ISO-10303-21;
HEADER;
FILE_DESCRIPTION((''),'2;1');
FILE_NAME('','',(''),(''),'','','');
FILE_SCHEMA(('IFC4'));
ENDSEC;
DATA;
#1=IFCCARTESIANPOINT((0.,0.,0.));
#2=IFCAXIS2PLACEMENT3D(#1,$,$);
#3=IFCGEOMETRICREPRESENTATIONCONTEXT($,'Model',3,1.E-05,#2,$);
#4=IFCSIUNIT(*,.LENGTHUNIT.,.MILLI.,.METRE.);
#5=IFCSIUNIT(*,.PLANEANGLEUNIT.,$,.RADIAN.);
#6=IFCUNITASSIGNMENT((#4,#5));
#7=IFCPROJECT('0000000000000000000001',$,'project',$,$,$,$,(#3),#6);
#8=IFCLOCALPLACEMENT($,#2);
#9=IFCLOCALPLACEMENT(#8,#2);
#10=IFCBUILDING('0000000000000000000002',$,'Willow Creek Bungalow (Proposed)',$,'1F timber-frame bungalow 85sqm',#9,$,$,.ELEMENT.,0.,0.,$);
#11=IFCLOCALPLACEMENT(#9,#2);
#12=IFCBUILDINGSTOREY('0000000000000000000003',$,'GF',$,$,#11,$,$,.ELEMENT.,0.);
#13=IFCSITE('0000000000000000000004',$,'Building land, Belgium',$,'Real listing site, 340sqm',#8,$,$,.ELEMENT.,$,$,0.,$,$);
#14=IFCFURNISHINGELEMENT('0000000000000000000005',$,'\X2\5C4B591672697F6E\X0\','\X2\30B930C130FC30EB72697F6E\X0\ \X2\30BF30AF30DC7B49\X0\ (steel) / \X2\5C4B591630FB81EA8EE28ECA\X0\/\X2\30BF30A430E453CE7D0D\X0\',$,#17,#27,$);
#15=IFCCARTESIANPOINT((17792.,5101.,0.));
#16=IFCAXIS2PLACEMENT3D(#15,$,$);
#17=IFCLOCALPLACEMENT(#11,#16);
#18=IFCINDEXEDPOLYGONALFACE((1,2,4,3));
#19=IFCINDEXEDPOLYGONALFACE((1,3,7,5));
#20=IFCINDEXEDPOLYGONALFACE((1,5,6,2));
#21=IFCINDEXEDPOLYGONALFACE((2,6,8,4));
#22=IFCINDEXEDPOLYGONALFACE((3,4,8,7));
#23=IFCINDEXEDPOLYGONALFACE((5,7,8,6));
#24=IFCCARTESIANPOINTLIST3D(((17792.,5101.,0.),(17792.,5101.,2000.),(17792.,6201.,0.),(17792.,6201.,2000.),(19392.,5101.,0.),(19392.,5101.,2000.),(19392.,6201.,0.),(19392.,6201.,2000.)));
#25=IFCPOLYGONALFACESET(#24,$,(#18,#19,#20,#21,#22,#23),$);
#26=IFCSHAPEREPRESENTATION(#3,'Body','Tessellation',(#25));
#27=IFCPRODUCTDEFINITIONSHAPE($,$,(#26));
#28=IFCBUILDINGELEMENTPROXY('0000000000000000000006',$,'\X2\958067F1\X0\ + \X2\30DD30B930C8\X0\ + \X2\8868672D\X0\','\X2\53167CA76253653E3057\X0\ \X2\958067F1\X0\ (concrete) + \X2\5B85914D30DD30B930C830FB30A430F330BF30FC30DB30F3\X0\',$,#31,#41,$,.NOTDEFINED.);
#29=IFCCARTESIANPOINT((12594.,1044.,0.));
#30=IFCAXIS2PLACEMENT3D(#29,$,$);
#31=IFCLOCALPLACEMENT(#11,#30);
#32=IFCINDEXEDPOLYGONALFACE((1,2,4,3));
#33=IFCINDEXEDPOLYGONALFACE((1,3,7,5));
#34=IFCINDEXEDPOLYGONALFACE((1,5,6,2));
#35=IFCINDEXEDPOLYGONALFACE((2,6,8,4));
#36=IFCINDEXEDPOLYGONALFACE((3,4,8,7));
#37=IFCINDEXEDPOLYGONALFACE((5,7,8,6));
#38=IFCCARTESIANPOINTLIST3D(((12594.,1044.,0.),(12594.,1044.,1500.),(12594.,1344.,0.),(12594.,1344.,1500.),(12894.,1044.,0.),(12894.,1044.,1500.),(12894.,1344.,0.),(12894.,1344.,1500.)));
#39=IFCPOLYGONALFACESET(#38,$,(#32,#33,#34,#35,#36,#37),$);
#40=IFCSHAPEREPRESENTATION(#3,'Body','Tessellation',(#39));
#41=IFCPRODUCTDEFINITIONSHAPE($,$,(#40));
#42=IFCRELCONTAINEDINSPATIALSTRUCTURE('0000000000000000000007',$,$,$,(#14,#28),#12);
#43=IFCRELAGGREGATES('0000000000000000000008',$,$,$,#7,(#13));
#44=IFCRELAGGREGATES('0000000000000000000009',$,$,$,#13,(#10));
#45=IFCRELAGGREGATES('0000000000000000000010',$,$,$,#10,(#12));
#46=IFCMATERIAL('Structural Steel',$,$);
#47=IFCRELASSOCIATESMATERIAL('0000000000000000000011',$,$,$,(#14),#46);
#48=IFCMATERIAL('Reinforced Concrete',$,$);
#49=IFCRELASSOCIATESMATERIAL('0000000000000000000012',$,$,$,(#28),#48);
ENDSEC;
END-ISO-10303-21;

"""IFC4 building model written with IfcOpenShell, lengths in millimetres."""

from ifc_helpers import new_model, si_unit, frame, frame_2d, origin, place, context, project, spatial, rectangle, extrude, material, element, save


model = new_model("IFC4")

# Units and contexts
model_context = context("Model", 3, precision=1e-05, world=origin())
ifc_project = project(units=[si_unit("LENGTHUNIT", "METRE", prefix="MILLI"), si_unit("PLANEANGLEUNIT", "RADIAN")], contexts=[model_context])

# Site, building, storey
site_placement = place(None, origin())
site = spatial("IfcSite", under=ifc_project, at=site_placement, Name="Building land, Belgium", ObjectType="Real listing site, 340sqm", CompositionType="ELEMENT", RefElevation=0.0)
building_placement = place(site_placement, origin())
building = spatial("IfcBuilding", under=site, at=building_placement, Name="Willow Creek Bungalow (Proposed)", ObjectType="1F timber-frame bungalow 85sqm", CompositionType="ELEMENT", ElevationOfRefHeight=0.0, ElevationOfTerrain=0.0)
storey_placement = place(building_placement, origin())
storey = spatial("IfcBuildingStorey", under=building, at=storey_placement, Name="GF", CompositionType="ELEMENT", Elevation=0.0)

# Shared definitions
ifc_material_1 = material(Name="Structural Steel")

# Shared definitions
ifc_material_2 = material(Name="Reinforced Concrete")

# Furnishing element
furnishing_1_placement = place(storey_placement, frame((17792.0, 5101.0, 0.0)))
element("IfcFurnishingElement", 1, at=furnishing_1_placement, inside=storey, material=ifc_material_1, Name="屋外物置", Description="スチール物置 タクボ等 (steel) / 屋外・自転車/タイヤ収納", context=model_context, shape_type="SweptSolid", body=[
    extrude(rectangle(XDim=1600.0, YDim=1100.0, at=frame_2d((800.0, 550.0))), frame((17792.0, 5101.0, 0.0)), (0.0, 0.0, 1.0), 2000.0),
])

# Building element proxy
proxy_placement = place(storey_placement, frame((12594.0, 1044.0, 0.0)))
element("IfcBuildingElementProxy", 2, at=proxy_placement, inside=storey, material=ifc_material_2, Name="門柱 + ポスト + 表札", Description="化粧打放し 門柱 (concrete) + 宅配ポスト・インターホン", PredefinedType="NOTDEFINED", context=model_context, shape_type="SweptSolid", body=[
    extrude(rectangle(XDim=300.0, YDim=300.0, at=frame_2d((150.0, 150.0))), frame((12594.0, 1044.0, 0.0)), (0.0, 0.0, 1.0), 1500.0),
])

save(model, "model.ifc")
